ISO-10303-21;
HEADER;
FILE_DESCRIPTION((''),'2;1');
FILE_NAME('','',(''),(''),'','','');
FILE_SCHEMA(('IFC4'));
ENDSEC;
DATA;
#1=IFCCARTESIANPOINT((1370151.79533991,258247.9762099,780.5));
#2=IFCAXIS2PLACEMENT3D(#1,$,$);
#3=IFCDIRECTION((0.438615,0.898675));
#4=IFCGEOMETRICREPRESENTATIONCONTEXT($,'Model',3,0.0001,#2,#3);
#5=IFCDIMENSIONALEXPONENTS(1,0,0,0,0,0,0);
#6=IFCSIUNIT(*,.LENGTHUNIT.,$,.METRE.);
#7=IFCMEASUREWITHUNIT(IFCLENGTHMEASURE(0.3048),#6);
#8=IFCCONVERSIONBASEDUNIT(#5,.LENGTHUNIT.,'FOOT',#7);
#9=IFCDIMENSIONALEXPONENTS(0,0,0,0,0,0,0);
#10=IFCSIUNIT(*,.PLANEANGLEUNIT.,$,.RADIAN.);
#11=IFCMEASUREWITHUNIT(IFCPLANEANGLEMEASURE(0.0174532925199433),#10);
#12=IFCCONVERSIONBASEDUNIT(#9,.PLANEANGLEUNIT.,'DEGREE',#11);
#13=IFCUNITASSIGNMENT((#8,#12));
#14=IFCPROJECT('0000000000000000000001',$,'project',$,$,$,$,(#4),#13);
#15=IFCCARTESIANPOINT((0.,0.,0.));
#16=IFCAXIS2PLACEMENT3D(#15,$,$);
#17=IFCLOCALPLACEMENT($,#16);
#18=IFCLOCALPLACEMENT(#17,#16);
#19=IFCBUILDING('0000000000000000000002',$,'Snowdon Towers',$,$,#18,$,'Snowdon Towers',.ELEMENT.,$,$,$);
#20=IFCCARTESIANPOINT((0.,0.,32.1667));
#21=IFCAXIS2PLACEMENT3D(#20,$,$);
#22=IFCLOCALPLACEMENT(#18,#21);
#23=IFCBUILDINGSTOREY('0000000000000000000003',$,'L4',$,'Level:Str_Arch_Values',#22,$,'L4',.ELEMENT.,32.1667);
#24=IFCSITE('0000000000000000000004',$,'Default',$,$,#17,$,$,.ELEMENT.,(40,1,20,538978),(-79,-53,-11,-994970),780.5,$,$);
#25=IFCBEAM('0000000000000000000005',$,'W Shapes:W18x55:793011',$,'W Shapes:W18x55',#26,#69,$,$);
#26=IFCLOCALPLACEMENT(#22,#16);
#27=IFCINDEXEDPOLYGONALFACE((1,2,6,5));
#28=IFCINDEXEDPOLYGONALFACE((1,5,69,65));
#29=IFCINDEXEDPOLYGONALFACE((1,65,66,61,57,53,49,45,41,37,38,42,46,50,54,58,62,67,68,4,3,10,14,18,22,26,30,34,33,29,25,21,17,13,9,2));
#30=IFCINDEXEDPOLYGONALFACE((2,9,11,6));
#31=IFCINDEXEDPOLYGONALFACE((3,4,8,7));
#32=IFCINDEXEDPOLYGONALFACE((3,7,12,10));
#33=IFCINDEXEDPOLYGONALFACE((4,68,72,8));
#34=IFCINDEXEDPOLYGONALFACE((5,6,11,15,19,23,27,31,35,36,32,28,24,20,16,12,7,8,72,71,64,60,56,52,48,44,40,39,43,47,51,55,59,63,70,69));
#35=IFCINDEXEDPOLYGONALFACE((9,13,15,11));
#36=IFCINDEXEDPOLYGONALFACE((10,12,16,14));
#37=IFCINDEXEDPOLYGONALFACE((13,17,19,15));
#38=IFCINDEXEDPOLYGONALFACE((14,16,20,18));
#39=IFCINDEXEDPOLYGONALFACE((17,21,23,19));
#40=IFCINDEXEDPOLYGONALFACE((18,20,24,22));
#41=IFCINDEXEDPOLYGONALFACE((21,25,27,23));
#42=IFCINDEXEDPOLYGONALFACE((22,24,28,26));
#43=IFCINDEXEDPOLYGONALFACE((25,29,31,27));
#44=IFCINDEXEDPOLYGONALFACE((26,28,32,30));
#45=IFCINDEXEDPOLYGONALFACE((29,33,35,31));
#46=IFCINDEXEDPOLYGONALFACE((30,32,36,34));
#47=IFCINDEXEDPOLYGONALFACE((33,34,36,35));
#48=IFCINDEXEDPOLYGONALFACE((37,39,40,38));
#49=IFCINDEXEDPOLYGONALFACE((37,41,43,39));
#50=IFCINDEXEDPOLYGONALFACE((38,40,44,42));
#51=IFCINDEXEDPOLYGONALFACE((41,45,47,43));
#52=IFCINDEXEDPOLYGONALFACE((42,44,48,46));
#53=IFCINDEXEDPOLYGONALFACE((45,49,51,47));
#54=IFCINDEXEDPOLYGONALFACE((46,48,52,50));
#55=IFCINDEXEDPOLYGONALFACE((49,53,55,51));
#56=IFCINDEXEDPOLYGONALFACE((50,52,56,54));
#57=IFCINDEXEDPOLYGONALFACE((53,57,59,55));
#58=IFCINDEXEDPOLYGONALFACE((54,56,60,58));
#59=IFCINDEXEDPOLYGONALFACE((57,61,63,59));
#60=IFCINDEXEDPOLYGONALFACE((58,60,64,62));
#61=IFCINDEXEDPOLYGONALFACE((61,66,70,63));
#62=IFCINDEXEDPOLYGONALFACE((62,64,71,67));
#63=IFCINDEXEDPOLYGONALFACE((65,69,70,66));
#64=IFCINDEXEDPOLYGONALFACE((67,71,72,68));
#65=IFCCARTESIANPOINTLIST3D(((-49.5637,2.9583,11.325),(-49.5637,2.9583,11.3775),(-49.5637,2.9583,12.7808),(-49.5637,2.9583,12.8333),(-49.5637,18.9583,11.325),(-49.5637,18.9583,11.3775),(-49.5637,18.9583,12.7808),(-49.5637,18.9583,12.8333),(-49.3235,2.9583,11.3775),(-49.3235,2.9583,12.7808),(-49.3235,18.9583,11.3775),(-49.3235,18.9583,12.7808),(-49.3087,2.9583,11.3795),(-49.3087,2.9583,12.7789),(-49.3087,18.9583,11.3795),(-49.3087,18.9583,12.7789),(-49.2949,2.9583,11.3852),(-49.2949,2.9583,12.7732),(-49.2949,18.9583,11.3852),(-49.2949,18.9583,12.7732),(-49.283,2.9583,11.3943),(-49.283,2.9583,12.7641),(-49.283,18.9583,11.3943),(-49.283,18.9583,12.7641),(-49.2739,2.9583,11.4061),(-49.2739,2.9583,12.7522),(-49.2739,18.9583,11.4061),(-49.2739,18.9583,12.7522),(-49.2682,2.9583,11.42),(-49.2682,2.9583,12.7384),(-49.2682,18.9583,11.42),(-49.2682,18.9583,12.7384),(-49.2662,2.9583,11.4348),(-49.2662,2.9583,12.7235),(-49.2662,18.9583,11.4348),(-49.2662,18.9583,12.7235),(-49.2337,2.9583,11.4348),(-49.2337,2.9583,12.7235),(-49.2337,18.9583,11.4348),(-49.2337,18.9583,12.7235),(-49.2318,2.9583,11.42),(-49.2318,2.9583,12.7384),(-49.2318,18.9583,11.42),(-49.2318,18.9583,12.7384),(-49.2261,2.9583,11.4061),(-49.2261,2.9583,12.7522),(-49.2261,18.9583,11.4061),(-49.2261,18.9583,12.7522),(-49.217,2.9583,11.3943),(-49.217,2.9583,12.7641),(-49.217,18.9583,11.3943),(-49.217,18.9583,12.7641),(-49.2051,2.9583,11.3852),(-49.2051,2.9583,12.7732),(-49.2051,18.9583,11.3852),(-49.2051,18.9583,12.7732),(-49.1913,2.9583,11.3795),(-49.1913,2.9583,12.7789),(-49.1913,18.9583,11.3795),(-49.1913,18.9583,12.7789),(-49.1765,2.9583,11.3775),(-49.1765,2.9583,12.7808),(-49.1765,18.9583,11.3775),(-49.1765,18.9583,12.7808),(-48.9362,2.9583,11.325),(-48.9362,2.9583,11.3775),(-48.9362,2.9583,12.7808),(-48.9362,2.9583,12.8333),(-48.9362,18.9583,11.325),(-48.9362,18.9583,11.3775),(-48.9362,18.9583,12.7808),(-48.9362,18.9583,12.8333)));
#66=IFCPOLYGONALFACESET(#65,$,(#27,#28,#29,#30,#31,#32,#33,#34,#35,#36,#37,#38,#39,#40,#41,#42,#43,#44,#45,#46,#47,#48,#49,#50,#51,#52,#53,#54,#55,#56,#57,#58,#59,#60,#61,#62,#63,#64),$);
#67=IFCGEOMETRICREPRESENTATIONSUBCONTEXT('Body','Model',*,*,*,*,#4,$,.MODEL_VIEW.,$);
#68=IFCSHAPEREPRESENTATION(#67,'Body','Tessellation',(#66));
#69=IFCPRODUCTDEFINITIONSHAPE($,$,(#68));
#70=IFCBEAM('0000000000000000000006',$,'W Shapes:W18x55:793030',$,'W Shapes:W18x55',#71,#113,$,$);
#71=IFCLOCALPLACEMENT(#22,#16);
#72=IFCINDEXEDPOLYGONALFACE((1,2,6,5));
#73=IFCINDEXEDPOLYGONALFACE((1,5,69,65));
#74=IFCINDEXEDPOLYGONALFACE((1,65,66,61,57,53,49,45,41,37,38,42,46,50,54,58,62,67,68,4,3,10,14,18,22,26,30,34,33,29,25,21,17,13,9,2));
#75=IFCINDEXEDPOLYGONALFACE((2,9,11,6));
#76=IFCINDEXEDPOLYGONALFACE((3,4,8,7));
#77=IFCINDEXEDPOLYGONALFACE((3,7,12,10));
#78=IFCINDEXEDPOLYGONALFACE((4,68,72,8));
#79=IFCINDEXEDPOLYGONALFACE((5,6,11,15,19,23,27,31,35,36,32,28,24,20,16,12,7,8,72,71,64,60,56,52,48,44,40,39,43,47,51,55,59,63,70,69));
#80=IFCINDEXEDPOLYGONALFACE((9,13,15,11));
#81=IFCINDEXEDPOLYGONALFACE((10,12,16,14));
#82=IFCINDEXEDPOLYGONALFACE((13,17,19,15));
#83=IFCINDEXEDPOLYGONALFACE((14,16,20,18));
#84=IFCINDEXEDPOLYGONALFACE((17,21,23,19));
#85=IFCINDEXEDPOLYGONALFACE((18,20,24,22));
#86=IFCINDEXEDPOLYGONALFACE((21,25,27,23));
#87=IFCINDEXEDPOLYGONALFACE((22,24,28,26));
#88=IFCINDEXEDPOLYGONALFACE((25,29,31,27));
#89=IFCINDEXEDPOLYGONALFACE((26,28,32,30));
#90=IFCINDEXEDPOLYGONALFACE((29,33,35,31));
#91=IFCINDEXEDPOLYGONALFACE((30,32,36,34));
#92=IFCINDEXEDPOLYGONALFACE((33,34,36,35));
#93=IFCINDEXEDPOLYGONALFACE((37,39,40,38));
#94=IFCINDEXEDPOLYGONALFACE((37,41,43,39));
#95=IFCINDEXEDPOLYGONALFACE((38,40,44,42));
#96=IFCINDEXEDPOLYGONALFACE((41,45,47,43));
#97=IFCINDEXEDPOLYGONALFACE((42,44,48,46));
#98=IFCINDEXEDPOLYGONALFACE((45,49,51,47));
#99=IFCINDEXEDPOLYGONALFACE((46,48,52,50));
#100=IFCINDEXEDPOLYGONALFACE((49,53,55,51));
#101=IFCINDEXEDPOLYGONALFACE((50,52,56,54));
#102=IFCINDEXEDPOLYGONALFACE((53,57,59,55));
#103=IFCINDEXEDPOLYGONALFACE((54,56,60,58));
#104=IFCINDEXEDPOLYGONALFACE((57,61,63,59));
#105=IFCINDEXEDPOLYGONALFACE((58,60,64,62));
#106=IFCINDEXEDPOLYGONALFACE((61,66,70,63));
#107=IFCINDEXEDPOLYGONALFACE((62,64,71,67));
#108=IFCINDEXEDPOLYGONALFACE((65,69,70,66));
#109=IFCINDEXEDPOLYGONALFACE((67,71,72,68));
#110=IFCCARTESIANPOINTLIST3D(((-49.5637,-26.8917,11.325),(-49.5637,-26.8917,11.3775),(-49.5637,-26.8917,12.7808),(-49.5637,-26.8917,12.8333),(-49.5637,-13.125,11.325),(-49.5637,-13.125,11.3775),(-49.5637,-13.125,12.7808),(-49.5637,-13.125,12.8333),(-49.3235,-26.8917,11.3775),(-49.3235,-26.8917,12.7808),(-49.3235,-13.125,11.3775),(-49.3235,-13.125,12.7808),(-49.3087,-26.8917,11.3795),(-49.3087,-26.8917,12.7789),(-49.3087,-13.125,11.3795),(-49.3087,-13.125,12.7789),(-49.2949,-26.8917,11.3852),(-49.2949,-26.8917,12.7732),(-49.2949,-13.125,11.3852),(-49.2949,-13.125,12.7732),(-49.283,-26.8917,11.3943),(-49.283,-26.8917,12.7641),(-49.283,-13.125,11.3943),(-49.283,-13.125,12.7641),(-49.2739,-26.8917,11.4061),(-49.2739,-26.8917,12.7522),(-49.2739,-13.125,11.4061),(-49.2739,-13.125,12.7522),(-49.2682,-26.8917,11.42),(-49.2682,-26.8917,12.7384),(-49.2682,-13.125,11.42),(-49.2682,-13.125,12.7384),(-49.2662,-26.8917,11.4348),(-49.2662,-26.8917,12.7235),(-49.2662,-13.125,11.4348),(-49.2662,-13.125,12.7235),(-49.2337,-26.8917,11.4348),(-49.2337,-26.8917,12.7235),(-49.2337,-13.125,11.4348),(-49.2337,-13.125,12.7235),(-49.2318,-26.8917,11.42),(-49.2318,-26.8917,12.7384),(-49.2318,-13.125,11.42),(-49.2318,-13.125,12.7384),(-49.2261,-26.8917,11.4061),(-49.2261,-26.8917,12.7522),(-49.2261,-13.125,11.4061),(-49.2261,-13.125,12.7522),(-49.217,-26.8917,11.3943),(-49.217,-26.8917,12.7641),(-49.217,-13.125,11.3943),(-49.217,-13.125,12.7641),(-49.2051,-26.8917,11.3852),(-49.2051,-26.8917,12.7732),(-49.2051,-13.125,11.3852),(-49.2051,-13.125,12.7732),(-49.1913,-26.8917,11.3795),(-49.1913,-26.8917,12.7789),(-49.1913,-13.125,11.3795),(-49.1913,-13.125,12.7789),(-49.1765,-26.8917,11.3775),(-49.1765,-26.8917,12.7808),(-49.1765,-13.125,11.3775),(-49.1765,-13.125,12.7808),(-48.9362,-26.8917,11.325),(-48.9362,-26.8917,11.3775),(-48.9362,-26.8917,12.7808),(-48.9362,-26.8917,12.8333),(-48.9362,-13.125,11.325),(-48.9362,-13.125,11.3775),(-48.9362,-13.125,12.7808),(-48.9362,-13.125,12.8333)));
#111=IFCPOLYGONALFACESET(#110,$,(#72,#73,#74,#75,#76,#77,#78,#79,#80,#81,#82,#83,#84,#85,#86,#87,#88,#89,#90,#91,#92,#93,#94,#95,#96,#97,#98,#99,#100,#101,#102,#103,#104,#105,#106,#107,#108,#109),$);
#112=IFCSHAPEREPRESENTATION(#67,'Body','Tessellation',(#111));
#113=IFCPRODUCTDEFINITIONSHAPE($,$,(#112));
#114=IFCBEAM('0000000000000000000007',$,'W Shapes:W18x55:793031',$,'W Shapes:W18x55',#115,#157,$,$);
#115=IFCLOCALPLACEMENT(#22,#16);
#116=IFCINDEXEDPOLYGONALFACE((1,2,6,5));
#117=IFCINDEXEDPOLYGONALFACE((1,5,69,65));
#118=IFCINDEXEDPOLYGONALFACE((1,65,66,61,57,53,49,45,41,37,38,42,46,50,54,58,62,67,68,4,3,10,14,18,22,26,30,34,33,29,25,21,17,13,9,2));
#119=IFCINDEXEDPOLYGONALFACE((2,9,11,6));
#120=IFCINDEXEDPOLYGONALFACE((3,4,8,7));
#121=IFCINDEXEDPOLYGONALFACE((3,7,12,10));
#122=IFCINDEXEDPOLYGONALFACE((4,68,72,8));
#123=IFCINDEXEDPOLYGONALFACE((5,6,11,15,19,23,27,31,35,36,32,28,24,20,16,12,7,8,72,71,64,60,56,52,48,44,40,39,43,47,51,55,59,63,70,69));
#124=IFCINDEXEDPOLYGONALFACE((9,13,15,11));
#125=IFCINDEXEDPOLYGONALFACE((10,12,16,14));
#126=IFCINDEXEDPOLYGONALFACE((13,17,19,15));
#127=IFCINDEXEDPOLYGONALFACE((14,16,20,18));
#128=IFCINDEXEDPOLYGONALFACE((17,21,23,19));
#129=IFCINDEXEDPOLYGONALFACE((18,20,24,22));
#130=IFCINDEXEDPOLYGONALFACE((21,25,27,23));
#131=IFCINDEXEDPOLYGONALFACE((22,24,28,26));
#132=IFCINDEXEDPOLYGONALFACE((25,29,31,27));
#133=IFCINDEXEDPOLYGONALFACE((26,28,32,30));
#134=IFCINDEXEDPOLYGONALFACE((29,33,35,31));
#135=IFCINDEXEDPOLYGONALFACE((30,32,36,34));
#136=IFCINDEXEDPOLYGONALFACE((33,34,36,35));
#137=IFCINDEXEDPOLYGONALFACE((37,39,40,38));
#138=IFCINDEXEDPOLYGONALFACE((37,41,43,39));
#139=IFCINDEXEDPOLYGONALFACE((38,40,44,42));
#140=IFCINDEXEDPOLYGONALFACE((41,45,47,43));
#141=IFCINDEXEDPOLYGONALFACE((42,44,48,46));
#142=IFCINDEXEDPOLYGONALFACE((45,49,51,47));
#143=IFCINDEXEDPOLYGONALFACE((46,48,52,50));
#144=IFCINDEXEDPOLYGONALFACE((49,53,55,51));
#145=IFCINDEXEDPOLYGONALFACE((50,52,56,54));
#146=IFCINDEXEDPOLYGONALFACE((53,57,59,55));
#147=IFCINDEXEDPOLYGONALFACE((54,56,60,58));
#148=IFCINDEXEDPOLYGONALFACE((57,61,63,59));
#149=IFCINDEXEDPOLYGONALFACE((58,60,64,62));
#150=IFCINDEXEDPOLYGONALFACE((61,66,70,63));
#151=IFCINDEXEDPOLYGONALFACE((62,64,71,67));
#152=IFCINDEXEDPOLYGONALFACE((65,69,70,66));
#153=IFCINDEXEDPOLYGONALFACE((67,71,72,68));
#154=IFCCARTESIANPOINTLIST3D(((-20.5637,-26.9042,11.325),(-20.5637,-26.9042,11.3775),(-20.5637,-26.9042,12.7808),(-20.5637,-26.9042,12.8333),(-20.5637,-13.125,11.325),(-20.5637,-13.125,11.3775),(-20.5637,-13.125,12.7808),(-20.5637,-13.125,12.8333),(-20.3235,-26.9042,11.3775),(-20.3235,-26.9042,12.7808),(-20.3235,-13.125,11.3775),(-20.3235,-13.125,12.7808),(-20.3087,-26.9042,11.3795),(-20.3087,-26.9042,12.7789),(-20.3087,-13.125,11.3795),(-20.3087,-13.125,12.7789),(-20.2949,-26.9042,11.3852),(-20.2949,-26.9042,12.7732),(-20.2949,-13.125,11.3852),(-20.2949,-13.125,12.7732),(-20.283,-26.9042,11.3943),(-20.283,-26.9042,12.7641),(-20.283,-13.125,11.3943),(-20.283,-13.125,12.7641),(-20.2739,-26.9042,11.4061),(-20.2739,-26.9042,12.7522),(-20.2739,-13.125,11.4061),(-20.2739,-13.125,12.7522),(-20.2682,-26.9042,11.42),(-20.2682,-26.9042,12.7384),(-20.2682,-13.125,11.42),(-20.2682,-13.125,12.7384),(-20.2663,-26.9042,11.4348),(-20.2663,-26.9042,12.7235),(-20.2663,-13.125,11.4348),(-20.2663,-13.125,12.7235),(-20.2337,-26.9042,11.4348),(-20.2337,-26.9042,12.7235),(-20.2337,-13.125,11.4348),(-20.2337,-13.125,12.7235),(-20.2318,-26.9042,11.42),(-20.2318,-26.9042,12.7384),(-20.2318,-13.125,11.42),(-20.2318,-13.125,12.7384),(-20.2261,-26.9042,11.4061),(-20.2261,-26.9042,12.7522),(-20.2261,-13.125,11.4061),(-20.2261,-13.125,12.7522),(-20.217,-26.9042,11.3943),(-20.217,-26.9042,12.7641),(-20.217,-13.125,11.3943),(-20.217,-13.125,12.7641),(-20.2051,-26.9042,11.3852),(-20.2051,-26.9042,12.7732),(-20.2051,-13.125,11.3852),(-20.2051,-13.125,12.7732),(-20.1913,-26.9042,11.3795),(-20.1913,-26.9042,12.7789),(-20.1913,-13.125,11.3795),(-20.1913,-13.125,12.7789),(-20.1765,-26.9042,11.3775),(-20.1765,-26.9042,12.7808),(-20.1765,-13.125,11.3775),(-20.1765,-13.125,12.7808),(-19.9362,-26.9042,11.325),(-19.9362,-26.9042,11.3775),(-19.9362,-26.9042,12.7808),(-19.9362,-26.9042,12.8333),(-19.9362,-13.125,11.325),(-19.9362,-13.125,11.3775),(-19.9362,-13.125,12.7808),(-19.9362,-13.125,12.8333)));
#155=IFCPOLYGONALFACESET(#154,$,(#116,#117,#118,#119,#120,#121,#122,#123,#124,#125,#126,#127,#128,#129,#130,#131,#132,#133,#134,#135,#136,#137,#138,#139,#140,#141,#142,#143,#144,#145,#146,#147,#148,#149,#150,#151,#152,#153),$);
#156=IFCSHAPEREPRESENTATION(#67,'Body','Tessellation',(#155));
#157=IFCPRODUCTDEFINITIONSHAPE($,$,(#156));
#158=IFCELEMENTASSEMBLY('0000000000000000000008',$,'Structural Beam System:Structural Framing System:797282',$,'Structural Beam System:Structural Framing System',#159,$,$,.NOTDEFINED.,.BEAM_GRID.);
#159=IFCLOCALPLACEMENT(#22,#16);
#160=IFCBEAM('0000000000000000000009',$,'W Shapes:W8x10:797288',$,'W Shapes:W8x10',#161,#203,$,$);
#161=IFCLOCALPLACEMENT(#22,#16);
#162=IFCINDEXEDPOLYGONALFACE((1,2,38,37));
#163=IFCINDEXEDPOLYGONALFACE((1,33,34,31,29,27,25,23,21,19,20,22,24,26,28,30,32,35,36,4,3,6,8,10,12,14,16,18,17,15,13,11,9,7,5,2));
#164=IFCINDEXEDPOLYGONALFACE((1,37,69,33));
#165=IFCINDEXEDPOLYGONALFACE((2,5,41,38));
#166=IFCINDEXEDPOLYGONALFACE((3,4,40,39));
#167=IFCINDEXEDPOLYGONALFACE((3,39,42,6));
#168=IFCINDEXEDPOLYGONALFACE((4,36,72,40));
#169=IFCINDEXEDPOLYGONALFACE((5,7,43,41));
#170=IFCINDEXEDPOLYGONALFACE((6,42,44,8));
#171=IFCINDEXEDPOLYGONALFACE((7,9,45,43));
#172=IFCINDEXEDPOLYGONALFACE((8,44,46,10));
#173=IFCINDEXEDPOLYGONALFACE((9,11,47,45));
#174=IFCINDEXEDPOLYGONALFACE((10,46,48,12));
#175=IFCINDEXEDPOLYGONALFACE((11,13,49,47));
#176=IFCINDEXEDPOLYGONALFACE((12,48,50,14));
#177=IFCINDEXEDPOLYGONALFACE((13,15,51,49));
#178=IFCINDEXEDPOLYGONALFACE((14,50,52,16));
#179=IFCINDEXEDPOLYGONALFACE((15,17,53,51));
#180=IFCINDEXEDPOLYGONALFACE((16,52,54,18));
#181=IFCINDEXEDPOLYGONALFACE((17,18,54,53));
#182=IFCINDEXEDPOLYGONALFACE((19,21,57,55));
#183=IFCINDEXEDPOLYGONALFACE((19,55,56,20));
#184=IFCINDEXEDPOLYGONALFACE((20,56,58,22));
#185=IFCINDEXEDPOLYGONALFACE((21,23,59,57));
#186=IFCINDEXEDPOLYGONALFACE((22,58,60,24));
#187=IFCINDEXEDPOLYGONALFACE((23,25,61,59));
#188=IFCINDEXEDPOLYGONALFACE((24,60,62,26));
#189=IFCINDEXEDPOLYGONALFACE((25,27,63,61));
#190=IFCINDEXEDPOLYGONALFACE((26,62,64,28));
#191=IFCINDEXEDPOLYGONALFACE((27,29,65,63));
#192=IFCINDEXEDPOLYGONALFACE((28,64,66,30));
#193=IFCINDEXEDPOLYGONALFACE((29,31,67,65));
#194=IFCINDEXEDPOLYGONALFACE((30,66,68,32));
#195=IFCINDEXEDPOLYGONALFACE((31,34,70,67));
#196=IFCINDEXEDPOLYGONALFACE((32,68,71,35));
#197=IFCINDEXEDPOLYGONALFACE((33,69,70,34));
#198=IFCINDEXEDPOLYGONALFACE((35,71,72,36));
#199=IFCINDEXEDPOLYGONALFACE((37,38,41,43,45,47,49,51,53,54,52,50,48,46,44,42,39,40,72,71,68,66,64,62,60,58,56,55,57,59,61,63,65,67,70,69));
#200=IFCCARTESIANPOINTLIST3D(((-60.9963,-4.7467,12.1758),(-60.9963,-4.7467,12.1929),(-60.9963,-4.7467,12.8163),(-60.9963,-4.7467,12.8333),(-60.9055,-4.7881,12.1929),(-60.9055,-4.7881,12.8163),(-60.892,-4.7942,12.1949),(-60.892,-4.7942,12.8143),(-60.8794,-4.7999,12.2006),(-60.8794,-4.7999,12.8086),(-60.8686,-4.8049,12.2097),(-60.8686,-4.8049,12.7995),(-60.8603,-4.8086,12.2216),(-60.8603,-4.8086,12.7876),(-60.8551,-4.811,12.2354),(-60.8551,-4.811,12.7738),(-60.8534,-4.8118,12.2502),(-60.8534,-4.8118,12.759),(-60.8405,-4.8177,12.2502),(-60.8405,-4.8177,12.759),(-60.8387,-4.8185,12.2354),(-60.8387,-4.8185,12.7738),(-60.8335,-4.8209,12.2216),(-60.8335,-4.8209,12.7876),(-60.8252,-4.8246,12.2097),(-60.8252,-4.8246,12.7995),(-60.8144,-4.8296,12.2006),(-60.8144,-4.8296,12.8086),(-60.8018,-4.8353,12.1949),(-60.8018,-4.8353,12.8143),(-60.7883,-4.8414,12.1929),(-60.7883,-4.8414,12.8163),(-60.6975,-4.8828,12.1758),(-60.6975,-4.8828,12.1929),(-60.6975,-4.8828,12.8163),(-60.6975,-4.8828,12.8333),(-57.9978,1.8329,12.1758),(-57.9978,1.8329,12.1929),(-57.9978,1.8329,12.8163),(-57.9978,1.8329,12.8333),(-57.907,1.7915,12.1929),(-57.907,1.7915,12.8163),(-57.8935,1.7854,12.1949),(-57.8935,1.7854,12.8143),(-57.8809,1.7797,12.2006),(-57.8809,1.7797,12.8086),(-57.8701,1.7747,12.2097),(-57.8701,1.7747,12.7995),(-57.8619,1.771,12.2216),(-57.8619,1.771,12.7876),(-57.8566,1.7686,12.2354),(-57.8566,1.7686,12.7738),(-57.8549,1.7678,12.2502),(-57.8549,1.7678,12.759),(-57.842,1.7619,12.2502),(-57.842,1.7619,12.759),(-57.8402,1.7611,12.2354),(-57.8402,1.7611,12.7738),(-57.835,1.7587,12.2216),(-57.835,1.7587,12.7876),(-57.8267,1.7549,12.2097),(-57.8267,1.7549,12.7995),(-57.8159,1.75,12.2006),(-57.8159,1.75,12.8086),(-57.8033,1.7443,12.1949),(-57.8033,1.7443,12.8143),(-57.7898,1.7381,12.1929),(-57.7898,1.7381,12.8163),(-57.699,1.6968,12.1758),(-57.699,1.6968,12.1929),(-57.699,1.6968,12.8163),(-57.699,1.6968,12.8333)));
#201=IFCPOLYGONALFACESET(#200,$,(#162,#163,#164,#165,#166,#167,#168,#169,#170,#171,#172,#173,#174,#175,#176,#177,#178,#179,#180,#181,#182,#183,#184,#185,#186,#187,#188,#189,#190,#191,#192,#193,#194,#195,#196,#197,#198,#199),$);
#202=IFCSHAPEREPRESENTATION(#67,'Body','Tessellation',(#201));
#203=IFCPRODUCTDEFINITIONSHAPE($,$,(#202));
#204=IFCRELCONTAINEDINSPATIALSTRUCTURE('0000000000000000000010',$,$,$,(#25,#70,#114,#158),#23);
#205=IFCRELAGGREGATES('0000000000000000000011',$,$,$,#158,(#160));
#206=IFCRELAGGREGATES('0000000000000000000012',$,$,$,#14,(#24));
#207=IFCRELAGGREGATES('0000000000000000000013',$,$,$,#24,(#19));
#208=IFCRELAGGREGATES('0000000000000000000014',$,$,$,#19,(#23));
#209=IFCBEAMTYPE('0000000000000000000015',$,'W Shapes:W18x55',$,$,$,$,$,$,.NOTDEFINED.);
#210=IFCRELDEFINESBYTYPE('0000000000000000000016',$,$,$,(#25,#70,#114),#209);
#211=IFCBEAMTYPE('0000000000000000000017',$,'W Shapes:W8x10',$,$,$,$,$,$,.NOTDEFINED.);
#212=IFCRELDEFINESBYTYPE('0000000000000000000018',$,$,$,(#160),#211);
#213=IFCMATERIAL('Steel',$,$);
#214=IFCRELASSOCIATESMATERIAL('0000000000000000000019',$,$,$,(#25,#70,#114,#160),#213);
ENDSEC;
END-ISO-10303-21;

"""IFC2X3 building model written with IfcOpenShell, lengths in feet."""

from ifc_helpers import new_model, entity, si_unit, converted_unit, direction, frame, frame_2d, origin, place, context, subcontext, project, spatial, i_section, extrude, material, type_object, element, aggregate, save


model = new_model("IFC2X3")

# Units and contexts
model_context = context("Model", 3, precision=0.0001, world=frame((1370151.79533991, 258247.9762099, 780.5)), true_north=direction((0.438615, 0.898675)))
body_context = subcontext(model_context, "Body", "Model", "MODEL_VIEW")
ifc_project = project(units=[converted_unit("LENGTHUNIT", "FOOT", entity("IfcLengthMeasure", 0.3048), si_unit("LENGTHUNIT", "METRE"), dimensions=[1, 0, 0, 0, 0, 0, 0]), converted_unit("PLANEANGLEUNIT", "DEGREE", entity("IfcPlaneAngleMeasure", 0.0174532925199433), si_unit("PLANEANGLEUNIT", "RADIAN"), dimensions=[0, 0, 0, 0, 0, 0, 0])], contexts=[model_context])

# Site, building, storey
site_placement = place(None, origin())
site = spatial("IfcSite", under=ifc_project, at=site_placement, Name="Default", CompositionType="ELEMENT", RefLatitude=(40, 1, 20, 538978), RefLongitude=(-79, -53, -11, -994970), RefElevation=780.5)
building_placement = place(site_placement, origin())
building = spatial("IfcBuilding", under=site, at=building_placement, Name="Snowdon Towers", LongName="Snowdon Towers", CompositionType="ELEMENT")
storey_placement = place(building_placement, frame((0.0, 0.0, 32.1667)))
storey = spatial("IfcBuildingStorey", under=building, at=storey_placement, Name="L4", ObjectType="Level:Str_Arch_Values", LongName="L4", CompositionType="ELEMENT", Elevation=32.1667)

# Beams
ifc_material_1 = material(Name="Steel")
beam_type_1 = type_object("IfcBeamType", Name="W Shapes:W18x55", PredefinedType="NOTDEFINED")
beam_1_placement = place(storey_placement, frame((-49.25, 19.2083, 12.8333), z_axis=(0.0, 0.0, 1.0), x_axis=(0.0, -1.0, 0.0)))
element("IfcBeam", 1, at=beam_1_placement, inside=storey, type_object=beam_type_1, material=ifc_material_1, Name="W Shapes:W18x55:793011", ObjectType="W Shapes:W18x55", context=body_context, shape_type="SweptSolid", body=[
    extrude(i_section(OverallWidth=0.6275, OverallDepth=1.5083, WebThickness=0.0325, FlangeThickness=0.0525, FilletRadius=0.0573, at=frame_2d((0.0, 0.0), x_axis=(0.0, 1.0))), frame((0.25, 0.0, -0.7542), z_axis=(1.0, 0.0, 0.0), x_axis=(0.0, 0.0, -1.0)), (0.0, 0.0, 1.0), 16.0),
])
beam_2_placement = place(storey_placement, frame((-49.25, -12.7083, 12.8333), z_axis=(0.0, 0.0, 1.0), x_axis=(0.0, -1.0, 0.0)))
element("IfcBeam", 2, at=beam_2_placement, inside=storey, type_object=beam_type_1, material=ifc_material_1, Name="W Shapes:W18x55:793030", ObjectType="W Shapes:W18x55", context=body_context, shape_type="SweptSolid", body=[
    extrude(i_section(OverallWidth=0.6275, OverallDepth=1.5083, WebThickness=0.0325, FlangeThickness=0.0525, FilletRadius=0.0573, at=frame_2d((0.0, 0.0), x_axis=(0.0, 1.0))), frame((0.4167, 0.0, -0.7542), z_axis=(1.0, 0.0, 0.0), x_axis=(0.0, 0.0, -1.0)), (0.0, 0.0, 1.0), 13.7667),
])
beam_3_placement = place(storey_placement, frame((-20.25, -12.7083, 12.8333), z_axis=(0.0, 0.0, 1.0), x_axis=(0.0, -1.0, 0.0)))
element("IfcBeam", 3, at=beam_3_placement, inside=storey, type_object=beam_type_1, material=ifc_material_1, Name="W Shapes:W18x55:793031", ObjectType="W Shapes:W18x55", context=body_context, shape_type="SweptSolid", body=[
    extrude(i_section(OverallWidth=0.6275, OverallDepth=1.5083, WebThickness=0.0325, FlangeThickness=0.0525, FilletRadius=0.0573, at=frame_2d((0.0, 0.0), x_axis=(0.0, 1.0))), frame((0.4167, 0.0, -0.7542), z_axis=(1.0, 0.0, 0.0), x_axis=(0.0, 0.0, -1.0)), (0.0, 0.0, 1.0), 13.7792),
])

# Element assembly, beam
assembly_placement = place(storey_placement, origin())
assembly = element("IfcElementAssembly", 4, at=assembly_placement, inside=storey, Name="Structural Beam System:Structural Framing System:797282", ObjectType="Structural Beam System:Structural Framing System", AssemblyPlace="NOTDEFINED", PredefinedType="BEAM_GRID")
beam_type_2 = type_object("IfcBeamType", Name="W Shapes:W8x10", PredefinedType="NOTDEFINED")
beam_4_placement = place(assembly_placement, frame((-60.9763, -5.0987, 12.8333), z_axis=(0.0, 0.0, 1.0), x_axis=(0.414693, 0.909961, 0.0)))
beam_4 = element("IfcBeam", 5, at=beam_4_placement, type_object=beam_type_2, material=ifc_material_1, Name="W Shapes:W8x10:797288", ObjectType="W Shapes:W8x10", context=body_context, shape_type="SweptSolid", body=[
    extrude(i_section(OverallWidth=0.3283, OverallDepth=0.6575, WebThickness=0.0142, FlangeThickness=0.0171, FilletRadius=0.0573, at=frame_2d((0.0, 0.0), x_axis=(0.0, 1.0))), frame((0.3121, 0.0, -0.3288), z_axis=(1.0, 0.0, 0.0), x_axis=(0.0, 0.0, -1.0)), (0.0, 0.0, 1.0), 7.2306),
])
aggregate(assembly, [beam_4])

save(model, "model.ifc")
